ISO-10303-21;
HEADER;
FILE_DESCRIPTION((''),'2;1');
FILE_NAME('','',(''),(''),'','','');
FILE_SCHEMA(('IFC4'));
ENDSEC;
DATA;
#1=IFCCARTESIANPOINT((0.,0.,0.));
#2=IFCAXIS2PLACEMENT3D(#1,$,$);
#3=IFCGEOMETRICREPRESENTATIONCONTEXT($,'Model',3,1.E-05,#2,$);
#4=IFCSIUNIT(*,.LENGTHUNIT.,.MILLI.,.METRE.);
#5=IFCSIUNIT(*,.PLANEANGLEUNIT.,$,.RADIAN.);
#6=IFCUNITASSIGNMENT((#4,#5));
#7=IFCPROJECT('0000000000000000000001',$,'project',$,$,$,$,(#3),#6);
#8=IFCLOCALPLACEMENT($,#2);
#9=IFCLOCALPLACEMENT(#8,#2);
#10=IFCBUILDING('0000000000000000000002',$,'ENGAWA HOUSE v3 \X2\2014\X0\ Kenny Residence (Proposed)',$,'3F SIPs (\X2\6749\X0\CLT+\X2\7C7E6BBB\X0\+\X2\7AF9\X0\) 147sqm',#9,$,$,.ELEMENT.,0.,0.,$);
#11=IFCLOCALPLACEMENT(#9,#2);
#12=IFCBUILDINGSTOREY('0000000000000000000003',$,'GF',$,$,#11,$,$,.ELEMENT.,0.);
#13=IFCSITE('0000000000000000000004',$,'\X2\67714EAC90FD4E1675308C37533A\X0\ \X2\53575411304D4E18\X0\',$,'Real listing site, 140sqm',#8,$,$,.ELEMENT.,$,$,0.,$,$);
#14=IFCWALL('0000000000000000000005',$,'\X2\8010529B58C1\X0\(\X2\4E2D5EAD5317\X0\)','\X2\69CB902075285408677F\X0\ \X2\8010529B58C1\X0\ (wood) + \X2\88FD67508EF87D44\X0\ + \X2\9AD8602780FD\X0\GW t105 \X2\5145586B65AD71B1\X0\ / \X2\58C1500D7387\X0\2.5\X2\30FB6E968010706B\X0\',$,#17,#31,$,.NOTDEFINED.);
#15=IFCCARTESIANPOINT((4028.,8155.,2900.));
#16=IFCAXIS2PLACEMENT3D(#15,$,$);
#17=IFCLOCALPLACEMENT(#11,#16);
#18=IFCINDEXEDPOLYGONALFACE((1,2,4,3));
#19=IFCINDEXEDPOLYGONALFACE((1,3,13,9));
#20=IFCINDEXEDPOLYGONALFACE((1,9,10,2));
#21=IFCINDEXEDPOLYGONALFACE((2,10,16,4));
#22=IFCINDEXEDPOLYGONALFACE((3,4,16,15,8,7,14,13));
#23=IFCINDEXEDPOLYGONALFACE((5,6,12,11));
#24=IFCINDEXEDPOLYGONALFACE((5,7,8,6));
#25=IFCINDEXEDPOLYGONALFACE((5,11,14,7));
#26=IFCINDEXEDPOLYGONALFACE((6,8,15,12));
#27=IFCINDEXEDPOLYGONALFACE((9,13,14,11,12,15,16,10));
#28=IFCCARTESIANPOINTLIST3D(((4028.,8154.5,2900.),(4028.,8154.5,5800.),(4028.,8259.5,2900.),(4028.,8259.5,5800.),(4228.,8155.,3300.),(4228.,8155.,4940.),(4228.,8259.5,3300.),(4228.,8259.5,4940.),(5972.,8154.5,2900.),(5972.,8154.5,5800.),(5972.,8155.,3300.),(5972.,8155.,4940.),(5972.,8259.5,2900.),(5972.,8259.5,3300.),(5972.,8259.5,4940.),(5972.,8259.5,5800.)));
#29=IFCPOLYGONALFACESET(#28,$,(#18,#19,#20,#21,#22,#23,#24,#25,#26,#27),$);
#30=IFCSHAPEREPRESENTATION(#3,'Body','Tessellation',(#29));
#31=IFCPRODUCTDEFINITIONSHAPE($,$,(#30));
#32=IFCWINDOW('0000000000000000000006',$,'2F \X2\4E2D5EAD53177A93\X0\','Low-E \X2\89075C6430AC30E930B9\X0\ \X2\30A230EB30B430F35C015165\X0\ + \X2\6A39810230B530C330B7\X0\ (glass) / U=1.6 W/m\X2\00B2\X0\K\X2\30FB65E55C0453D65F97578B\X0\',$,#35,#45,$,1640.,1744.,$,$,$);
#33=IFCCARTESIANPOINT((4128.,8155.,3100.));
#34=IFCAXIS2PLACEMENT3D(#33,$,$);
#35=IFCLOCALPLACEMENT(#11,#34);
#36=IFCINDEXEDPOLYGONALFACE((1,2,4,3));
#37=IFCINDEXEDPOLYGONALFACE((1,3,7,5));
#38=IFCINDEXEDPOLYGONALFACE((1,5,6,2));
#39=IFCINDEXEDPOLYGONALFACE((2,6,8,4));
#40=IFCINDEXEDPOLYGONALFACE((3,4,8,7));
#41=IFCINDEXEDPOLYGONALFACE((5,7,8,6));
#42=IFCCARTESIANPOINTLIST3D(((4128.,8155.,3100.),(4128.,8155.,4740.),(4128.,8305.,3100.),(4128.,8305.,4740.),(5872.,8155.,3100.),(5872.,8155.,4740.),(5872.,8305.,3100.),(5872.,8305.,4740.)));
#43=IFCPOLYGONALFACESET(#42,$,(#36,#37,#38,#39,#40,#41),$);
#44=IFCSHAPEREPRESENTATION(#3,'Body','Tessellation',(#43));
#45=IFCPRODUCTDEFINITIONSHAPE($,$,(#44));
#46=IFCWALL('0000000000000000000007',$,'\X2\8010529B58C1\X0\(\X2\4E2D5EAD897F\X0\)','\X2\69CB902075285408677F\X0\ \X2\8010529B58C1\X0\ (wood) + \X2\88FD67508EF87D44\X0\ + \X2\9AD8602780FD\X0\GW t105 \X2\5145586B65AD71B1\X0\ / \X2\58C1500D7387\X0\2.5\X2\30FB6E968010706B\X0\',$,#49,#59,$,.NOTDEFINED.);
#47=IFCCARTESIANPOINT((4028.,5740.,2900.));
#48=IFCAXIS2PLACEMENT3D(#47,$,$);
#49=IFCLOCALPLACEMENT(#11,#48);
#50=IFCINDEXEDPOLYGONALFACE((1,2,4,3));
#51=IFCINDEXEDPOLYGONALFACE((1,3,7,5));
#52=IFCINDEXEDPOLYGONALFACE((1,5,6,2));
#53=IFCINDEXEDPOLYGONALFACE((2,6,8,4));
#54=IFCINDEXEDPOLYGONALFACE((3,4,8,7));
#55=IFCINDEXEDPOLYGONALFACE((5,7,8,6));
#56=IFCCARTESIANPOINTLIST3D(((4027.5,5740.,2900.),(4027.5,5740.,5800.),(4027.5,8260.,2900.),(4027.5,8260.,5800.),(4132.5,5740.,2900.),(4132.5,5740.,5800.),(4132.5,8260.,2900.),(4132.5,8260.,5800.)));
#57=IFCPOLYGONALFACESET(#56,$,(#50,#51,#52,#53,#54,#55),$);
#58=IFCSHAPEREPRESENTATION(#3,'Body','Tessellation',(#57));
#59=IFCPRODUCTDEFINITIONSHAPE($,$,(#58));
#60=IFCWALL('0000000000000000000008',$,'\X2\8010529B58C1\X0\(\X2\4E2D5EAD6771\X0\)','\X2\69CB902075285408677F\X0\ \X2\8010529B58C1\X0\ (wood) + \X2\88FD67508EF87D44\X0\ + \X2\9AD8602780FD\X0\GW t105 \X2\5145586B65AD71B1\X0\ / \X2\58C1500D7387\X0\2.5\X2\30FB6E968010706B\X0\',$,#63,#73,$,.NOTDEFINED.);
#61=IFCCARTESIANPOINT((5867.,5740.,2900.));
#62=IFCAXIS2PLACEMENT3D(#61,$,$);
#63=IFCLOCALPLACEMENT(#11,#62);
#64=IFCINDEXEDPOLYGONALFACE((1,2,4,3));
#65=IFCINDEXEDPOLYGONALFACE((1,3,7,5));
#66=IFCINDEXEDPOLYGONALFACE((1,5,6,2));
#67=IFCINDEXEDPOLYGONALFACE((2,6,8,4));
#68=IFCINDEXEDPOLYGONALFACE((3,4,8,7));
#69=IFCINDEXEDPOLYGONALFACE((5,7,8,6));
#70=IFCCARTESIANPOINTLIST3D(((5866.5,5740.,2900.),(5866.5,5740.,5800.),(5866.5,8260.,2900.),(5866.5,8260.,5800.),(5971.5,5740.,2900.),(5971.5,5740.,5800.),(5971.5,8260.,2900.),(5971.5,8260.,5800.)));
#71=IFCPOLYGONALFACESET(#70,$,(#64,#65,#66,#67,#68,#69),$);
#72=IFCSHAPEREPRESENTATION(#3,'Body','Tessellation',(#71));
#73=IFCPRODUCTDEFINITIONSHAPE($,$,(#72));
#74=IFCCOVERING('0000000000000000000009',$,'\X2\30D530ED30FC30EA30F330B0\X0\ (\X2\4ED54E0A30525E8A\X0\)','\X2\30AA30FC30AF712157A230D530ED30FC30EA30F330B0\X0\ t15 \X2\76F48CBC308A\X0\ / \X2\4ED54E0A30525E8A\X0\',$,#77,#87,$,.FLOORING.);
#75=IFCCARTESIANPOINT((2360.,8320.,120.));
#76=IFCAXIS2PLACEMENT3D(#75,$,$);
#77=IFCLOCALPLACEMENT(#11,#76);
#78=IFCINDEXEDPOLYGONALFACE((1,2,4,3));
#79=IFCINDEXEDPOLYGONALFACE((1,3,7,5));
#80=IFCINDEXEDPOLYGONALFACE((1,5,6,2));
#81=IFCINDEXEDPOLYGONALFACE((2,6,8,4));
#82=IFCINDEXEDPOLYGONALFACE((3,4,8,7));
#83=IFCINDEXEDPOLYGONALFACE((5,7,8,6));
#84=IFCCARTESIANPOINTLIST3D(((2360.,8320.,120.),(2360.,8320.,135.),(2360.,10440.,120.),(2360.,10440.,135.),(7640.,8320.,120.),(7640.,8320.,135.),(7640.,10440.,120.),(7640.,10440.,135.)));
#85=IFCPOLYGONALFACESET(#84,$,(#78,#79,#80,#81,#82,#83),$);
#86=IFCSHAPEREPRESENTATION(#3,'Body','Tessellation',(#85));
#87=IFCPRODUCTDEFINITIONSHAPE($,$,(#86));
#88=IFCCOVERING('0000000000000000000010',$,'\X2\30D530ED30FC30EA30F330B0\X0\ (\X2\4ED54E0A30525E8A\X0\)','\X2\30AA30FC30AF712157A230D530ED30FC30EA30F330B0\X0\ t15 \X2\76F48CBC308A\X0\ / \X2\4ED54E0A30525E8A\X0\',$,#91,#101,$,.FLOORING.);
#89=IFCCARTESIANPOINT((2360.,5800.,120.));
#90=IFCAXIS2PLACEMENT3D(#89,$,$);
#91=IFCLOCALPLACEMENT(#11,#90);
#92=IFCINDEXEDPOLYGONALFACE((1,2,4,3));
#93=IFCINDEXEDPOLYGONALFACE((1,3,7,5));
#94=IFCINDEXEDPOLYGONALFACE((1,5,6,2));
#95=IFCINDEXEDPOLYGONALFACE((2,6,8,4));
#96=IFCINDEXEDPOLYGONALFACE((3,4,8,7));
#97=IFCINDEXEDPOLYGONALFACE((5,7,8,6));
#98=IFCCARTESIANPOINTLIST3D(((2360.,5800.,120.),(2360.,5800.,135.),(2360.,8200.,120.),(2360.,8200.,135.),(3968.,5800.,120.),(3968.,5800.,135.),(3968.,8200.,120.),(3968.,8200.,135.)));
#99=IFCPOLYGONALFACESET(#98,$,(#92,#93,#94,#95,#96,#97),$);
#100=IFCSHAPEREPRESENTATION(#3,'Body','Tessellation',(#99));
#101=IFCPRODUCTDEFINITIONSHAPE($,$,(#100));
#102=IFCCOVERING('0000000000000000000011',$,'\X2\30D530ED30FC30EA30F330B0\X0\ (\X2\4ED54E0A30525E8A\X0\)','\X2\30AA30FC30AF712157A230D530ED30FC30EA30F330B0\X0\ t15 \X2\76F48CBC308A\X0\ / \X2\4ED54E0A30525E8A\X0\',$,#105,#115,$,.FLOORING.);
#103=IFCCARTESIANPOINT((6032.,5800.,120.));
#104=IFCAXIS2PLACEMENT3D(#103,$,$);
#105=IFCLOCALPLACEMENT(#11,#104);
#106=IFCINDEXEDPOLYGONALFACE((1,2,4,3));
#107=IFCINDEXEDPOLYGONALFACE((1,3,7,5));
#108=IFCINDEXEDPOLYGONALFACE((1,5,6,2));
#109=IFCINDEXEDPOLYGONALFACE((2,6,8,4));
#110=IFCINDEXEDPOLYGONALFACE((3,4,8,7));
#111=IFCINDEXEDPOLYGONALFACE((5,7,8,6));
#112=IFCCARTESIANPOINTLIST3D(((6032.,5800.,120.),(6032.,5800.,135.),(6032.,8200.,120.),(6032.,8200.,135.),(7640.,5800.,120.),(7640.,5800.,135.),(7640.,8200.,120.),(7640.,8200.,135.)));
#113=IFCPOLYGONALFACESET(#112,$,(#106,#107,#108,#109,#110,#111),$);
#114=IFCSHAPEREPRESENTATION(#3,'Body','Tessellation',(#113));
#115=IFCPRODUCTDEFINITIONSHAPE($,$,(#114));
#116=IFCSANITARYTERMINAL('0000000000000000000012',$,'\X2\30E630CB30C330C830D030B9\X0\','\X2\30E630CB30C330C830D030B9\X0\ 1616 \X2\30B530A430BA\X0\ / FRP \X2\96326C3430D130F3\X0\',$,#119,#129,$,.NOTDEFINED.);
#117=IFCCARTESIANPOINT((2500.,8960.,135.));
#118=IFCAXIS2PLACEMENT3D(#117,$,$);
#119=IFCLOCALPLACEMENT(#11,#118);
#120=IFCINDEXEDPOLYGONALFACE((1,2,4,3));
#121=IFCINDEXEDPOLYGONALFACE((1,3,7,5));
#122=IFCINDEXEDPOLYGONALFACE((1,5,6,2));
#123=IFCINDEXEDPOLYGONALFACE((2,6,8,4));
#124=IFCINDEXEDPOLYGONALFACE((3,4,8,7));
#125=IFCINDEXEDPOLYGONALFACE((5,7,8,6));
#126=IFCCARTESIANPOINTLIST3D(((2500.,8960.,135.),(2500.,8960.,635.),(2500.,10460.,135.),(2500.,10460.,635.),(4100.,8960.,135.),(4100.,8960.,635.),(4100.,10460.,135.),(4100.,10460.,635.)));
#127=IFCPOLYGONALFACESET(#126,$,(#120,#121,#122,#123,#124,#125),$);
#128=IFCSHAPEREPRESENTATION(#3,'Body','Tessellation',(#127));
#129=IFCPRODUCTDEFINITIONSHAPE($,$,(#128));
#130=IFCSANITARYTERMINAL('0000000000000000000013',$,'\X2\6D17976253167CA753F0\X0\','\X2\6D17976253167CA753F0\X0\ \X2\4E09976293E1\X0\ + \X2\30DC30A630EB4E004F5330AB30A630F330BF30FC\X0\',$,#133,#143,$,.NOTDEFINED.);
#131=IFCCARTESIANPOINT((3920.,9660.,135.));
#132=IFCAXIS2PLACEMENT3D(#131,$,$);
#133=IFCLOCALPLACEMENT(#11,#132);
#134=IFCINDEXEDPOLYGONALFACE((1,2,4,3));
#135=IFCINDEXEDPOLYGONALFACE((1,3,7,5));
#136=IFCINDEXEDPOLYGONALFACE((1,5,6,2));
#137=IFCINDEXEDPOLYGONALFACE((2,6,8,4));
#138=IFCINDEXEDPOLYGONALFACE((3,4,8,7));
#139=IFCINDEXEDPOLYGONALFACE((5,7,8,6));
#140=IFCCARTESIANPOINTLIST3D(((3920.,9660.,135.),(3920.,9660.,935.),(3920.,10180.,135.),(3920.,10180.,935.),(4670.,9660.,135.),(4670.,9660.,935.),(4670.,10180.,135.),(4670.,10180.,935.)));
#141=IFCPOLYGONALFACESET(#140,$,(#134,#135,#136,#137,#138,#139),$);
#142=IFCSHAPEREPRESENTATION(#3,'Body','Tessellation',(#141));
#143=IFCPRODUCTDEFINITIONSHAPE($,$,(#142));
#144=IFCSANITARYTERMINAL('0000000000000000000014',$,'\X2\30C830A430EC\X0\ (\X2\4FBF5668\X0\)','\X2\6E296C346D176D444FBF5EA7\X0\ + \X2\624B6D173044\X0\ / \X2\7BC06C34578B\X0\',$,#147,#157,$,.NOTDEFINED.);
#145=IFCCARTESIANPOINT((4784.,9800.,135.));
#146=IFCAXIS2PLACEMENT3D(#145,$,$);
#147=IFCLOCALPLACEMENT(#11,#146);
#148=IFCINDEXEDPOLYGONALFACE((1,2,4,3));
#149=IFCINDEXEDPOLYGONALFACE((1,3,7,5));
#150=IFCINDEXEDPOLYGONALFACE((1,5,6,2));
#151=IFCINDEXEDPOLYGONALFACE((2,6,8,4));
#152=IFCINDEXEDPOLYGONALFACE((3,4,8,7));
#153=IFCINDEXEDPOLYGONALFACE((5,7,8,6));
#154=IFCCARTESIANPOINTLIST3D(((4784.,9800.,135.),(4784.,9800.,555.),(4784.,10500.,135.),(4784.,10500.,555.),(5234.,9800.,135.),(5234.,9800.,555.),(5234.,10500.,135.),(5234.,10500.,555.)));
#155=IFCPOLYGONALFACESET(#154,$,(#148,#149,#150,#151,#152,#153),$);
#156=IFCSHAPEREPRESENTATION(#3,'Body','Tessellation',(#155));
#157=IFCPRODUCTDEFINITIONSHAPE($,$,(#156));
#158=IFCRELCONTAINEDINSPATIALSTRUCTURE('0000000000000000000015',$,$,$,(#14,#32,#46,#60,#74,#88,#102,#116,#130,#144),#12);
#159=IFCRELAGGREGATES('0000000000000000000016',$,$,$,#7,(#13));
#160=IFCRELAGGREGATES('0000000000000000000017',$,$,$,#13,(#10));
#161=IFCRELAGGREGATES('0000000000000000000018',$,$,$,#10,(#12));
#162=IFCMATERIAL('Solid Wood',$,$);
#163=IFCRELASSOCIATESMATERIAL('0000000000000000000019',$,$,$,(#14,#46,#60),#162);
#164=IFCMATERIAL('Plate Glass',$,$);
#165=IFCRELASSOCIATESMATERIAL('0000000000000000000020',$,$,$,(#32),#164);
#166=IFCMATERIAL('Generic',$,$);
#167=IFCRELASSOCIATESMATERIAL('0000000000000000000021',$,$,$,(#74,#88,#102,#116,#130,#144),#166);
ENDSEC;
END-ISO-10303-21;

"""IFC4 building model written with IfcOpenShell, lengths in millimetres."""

from ifc_helpers import new_model, si_unit, frame, frame_2d, origin, place, context, project, spatial, rectangle, extrude, material, element, fill, save


model = new_model("IFC4")

# Units and contexts
model_context = context("Model", 3, precision=1e-05, world=origin())
ifc_project = project(units=[si_unit("LENGTHUNIT", "METRE", prefix="MILLI"), si_unit("PLANEANGLEUNIT", "RADIAN")], contexts=[model_context])

# Site, building, storey
site_placement = place(None, origin())
site = spatial("IfcSite", under=ifc_project, at=site_placement, Name="東京都世田谷区 南向き丘", ObjectType="Real listing site, 140sqm", CompositionType="ELEMENT", RefElevation=0.0)
building_placement = place(site_placement, origin())
building = spatial("IfcBuilding", under=site, at=building_placement, Name="ENGAWA HOUSE v3 — Kenny Residence (Proposed)", ObjectType="3F SIPs (杉CLT+籾殻+竹) 147sqm", CompositionType="ELEMENT", ElevationOfRefHeight=0.0, ElevationOfTerrain=0.0)
storey_placement = place(building_placement, origin())
storey = spatial("IfcBuildingStorey", under=building, at=storey_placement, Name="GF", CompositionType="ELEMENT", Elevation=0.0)

# Shared definitions
ifc_material_1 = material(Name="Solid Wood")

# Shared definitions
ifc_material_2 = material(Name="Plate Glass")

# Wall, opening, window
wall_1_placement = place(storey_placement, frame((4028.0, 8155.0, 2900.0)))
wall_1 = element("IfcWall", 1, at=wall_1_placement, inside=storey, material=ifc_material_1, Name="耐力壁(中庭北)", Description="構造用合板 耐力壁 (wood) + 製材軸組 + 高性能GW t105 充填断熱 / 壁倍率2.5・準耐火", PredefinedType="NOTDEFINED", context=model_context, shape_type="SweptSolid", body=[
    extrude(rectangle(XDim=1944.0, YDim=105.0, at=frame_2d((972.0, 52.0))), frame((4028.0, 8155.0, 2900.0)), (0.0, 0.0, 1.0), 2900.0),
])
opening_1_placement = place(storey_placement, frame((4128.0, 8155.0, 3100.0)))
opening_1 = element("IfcOpeningElement", 2, at=opening_1_placement, cuts=wall_1, PredefinedType="NOTDEFINED", context=model_context, shape_type="SweptSolid", body=[
    extrude(rectangle(XDim=1744.0, YDim=150.0, at=frame_2d((872.0, 75.0))), frame((4128.0, 8155.0, 3100.0)), (0.0, 0.0, 1.0), 1640.0),
])
window_1_placement = place(storey_placement, frame((4128.0, 8155.0, 3100.0)))
window_1 = element("IfcWindow", 3, at=window_1_placement, inside=storey, material=ifc_material_2, Name="2F 中庭北窓", Description="Low-E 複層ガラス アルゴン封入 + 樹脂サッシ (glass) / U=1.6 W/m²K・日射取得型", OverallHeight=1640.0, OverallWidth=1744.0, context=model_context, shape_type="SweptSolid", body=[
    extrude(rectangle(XDim=1744.0, YDim=150.0, at=frame_2d((872.0, 75.0))), frame((4128.0, 8155.0, 3100.0)), (0.0, 0.0, 1.0), 1640.0),
])
fill(opening_1, window_1)

# Walls
wall_2_placement = place(storey_placement, frame((4028.0, 5740.0, 2900.0)))
element("IfcWall", 4, at=wall_2_placement, inside=storey, material=ifc_material_1, Name="耐力壁(中庭西)", Description="構造用合板 耐力壁 (wood) + 製材軸組 + 高性能GW t105 充填断熱 / 壁倍率2.5・準耐火", PredefinedType="NOTDEFINED", context=model_context, shape_type="SweptSolid", body=[
    extrude(rectangle(XDim=105.0, YDim=2520.0, at=frame_2d((52.0, 1260.0))), frame((4028.0, 5740.0, 2900.0)), (0.0, 0.0, 1.0), 2900.0),
])
wall_3_placement = place(storey_placement, frame((5867.0, 5740.0, 2900.0)))
element("IfcWall", 5, at=wall_3_placement, inside=storey, material=ifc_material_1, Name="耐力壁(中庭東)", Description="構造用合板 耐力壁 (wood) + 製材軸組 + 高性能GW t105 充填断熱 / 壁倍率2.5・準耐火", PredefinedType="NOTDEFINED", context=model_context, shape_type="SweptSolid", body=[
    extrude(rectangle(XDim=105.0, YDim=2520.0, at=frame_2d((52.0, 1260.0))), frame((5867.0, 5740.0, 2900.0)), (0.0, 0.0, 1.0), 2900.0),
])

# Coverings
ifc_material_3 = material(Name="Generic")
covering_1_placement = place(storey_placement, frame((2360.0, 8320.0, 120.0)))
element("IfcCovering", 6, at=covering_1_placement, inside=storey, material=ifc_material_3, Name="フローリング (仕上げ床)", Description="オーク無垢フローリング t15 直貼り / 仕上げ床", PredefinedType="FLOORING", context=model_context, shape_type="SweptSolid", body=[
    extrude(rectangle(XDim=5280.0, YDim=2120.0, at=frame_2d((2640.0, 1060.0))), frame((2360.0, 8320.0, 120.0)), (0.0, 0.0, 1.0), 15.0),
])
covering_2_placement = place(storey_placement, frame((2360.0, 5800.0, 120.0)))
element("IfcCovering", 7, at=covering_2_placement, inside=storey, material=ifc_material_3, Name="フローリング (仕上げ床)", Description="オーク無垢フローリング t15 直貼り / 仕上げ床", PredefinedType="FLOORING", context=model_context, shape_type="SweptSolid", body=[
    extrude(rectangle(XDim=1608.0, YDim=2400.0, at=frame_2d((804.0, 1200.0))), frame((2360.0, 5800.0, 120.0)), (0.0, 0.0, 1.0), 15.0),
])
covering_3_placement = place(storey_placement, frame((6032.0, 5800.0, 120.0)))
element("IfcCovering", 8, at=covering_3_placement, inside=storey, material=ifc_material_3, Name="フローリング (仕上げ床)", Description="オーク無垢フローリング t15 直貼り / 仕上げ床", PredefinedType="FLOORING", context=model_context, shape_type="SweptSolid", body=[
    extrude(rectangle(XDim=1608.0, YDim=2400.0, at=frame_2d((804.0, 1200.0))), frame((6032.0, 5800.0, 120.0)), (0.0, 0.0, 1.0), 15.0),
])

# Sanitary terminals
sanitary_terminal_1_placement = place(storey_placement, frame((2500.0, 8960.0, 135.0)))
element("IfcSanitaryTerminal", 9, at=sanitary_terminal_1_placement, inside=storey, material=ifc_material_3, Name="ユニットバス", Description="ユニットバス 1616 サイズ / FRP 防水パン", PredefinedType="NOTDEFINED", context=model_context, shape_type="SweptSolid", body=[
    extrude(rectangle(XDim=1600.0, YDim=1500.0, at=frame_2d((800.0, 750.0))), frame((2500.0, 8960.0, 135.0)), (0.0, 0.0, 1.0), 500.0),
])
sanitary_terminal_2_placement = place(storey_placement, frame((3920.0, 9660.0, 135.0)))
element("IfcSanitaryTerminal", 10, at=sanitary_terminal_2_placement, inside=storey, material=ifc_material_3, Name="洗面化粧台", Description="洗面化粧台 三面鏡 + ボウル一体カウンター", PredefinedType="NOTDEFINED", context=model_context, shape_type="SweptSolid", body=[
    extrude(rectangle(XDim=750.0, YDim=520.0, at=frame_2d((375.0, 260.0))), frame((3920.0, 9660.0, 135.0)), (0.0, 0.0, 1.0), 800.0),
])
sanitary_terminal_3_placement = place(storey_placement, frame((4784.0, 9800.0, 135.0)))
element("IfcSanitaryTerminal", 11, at=sanitary_terminal_3_placement, inside=storey, material=ifc_material_3, Name="トイレ (便器)", Description="温水洗浄便座 + 手洗い / 節水型", PredefinedType="NOTDEFINED", context=model_context, shape_type="SweptSolid", body=[
    extrude(rectangle(XDim=450.0, YDim=700.0, at=frame_2d((225.0, 350.0))), frame((4784.0, 9800.0, 135.0)), (0.0, 0.0, 1.0), 420.0),
])

save(model, "model.ifc")
